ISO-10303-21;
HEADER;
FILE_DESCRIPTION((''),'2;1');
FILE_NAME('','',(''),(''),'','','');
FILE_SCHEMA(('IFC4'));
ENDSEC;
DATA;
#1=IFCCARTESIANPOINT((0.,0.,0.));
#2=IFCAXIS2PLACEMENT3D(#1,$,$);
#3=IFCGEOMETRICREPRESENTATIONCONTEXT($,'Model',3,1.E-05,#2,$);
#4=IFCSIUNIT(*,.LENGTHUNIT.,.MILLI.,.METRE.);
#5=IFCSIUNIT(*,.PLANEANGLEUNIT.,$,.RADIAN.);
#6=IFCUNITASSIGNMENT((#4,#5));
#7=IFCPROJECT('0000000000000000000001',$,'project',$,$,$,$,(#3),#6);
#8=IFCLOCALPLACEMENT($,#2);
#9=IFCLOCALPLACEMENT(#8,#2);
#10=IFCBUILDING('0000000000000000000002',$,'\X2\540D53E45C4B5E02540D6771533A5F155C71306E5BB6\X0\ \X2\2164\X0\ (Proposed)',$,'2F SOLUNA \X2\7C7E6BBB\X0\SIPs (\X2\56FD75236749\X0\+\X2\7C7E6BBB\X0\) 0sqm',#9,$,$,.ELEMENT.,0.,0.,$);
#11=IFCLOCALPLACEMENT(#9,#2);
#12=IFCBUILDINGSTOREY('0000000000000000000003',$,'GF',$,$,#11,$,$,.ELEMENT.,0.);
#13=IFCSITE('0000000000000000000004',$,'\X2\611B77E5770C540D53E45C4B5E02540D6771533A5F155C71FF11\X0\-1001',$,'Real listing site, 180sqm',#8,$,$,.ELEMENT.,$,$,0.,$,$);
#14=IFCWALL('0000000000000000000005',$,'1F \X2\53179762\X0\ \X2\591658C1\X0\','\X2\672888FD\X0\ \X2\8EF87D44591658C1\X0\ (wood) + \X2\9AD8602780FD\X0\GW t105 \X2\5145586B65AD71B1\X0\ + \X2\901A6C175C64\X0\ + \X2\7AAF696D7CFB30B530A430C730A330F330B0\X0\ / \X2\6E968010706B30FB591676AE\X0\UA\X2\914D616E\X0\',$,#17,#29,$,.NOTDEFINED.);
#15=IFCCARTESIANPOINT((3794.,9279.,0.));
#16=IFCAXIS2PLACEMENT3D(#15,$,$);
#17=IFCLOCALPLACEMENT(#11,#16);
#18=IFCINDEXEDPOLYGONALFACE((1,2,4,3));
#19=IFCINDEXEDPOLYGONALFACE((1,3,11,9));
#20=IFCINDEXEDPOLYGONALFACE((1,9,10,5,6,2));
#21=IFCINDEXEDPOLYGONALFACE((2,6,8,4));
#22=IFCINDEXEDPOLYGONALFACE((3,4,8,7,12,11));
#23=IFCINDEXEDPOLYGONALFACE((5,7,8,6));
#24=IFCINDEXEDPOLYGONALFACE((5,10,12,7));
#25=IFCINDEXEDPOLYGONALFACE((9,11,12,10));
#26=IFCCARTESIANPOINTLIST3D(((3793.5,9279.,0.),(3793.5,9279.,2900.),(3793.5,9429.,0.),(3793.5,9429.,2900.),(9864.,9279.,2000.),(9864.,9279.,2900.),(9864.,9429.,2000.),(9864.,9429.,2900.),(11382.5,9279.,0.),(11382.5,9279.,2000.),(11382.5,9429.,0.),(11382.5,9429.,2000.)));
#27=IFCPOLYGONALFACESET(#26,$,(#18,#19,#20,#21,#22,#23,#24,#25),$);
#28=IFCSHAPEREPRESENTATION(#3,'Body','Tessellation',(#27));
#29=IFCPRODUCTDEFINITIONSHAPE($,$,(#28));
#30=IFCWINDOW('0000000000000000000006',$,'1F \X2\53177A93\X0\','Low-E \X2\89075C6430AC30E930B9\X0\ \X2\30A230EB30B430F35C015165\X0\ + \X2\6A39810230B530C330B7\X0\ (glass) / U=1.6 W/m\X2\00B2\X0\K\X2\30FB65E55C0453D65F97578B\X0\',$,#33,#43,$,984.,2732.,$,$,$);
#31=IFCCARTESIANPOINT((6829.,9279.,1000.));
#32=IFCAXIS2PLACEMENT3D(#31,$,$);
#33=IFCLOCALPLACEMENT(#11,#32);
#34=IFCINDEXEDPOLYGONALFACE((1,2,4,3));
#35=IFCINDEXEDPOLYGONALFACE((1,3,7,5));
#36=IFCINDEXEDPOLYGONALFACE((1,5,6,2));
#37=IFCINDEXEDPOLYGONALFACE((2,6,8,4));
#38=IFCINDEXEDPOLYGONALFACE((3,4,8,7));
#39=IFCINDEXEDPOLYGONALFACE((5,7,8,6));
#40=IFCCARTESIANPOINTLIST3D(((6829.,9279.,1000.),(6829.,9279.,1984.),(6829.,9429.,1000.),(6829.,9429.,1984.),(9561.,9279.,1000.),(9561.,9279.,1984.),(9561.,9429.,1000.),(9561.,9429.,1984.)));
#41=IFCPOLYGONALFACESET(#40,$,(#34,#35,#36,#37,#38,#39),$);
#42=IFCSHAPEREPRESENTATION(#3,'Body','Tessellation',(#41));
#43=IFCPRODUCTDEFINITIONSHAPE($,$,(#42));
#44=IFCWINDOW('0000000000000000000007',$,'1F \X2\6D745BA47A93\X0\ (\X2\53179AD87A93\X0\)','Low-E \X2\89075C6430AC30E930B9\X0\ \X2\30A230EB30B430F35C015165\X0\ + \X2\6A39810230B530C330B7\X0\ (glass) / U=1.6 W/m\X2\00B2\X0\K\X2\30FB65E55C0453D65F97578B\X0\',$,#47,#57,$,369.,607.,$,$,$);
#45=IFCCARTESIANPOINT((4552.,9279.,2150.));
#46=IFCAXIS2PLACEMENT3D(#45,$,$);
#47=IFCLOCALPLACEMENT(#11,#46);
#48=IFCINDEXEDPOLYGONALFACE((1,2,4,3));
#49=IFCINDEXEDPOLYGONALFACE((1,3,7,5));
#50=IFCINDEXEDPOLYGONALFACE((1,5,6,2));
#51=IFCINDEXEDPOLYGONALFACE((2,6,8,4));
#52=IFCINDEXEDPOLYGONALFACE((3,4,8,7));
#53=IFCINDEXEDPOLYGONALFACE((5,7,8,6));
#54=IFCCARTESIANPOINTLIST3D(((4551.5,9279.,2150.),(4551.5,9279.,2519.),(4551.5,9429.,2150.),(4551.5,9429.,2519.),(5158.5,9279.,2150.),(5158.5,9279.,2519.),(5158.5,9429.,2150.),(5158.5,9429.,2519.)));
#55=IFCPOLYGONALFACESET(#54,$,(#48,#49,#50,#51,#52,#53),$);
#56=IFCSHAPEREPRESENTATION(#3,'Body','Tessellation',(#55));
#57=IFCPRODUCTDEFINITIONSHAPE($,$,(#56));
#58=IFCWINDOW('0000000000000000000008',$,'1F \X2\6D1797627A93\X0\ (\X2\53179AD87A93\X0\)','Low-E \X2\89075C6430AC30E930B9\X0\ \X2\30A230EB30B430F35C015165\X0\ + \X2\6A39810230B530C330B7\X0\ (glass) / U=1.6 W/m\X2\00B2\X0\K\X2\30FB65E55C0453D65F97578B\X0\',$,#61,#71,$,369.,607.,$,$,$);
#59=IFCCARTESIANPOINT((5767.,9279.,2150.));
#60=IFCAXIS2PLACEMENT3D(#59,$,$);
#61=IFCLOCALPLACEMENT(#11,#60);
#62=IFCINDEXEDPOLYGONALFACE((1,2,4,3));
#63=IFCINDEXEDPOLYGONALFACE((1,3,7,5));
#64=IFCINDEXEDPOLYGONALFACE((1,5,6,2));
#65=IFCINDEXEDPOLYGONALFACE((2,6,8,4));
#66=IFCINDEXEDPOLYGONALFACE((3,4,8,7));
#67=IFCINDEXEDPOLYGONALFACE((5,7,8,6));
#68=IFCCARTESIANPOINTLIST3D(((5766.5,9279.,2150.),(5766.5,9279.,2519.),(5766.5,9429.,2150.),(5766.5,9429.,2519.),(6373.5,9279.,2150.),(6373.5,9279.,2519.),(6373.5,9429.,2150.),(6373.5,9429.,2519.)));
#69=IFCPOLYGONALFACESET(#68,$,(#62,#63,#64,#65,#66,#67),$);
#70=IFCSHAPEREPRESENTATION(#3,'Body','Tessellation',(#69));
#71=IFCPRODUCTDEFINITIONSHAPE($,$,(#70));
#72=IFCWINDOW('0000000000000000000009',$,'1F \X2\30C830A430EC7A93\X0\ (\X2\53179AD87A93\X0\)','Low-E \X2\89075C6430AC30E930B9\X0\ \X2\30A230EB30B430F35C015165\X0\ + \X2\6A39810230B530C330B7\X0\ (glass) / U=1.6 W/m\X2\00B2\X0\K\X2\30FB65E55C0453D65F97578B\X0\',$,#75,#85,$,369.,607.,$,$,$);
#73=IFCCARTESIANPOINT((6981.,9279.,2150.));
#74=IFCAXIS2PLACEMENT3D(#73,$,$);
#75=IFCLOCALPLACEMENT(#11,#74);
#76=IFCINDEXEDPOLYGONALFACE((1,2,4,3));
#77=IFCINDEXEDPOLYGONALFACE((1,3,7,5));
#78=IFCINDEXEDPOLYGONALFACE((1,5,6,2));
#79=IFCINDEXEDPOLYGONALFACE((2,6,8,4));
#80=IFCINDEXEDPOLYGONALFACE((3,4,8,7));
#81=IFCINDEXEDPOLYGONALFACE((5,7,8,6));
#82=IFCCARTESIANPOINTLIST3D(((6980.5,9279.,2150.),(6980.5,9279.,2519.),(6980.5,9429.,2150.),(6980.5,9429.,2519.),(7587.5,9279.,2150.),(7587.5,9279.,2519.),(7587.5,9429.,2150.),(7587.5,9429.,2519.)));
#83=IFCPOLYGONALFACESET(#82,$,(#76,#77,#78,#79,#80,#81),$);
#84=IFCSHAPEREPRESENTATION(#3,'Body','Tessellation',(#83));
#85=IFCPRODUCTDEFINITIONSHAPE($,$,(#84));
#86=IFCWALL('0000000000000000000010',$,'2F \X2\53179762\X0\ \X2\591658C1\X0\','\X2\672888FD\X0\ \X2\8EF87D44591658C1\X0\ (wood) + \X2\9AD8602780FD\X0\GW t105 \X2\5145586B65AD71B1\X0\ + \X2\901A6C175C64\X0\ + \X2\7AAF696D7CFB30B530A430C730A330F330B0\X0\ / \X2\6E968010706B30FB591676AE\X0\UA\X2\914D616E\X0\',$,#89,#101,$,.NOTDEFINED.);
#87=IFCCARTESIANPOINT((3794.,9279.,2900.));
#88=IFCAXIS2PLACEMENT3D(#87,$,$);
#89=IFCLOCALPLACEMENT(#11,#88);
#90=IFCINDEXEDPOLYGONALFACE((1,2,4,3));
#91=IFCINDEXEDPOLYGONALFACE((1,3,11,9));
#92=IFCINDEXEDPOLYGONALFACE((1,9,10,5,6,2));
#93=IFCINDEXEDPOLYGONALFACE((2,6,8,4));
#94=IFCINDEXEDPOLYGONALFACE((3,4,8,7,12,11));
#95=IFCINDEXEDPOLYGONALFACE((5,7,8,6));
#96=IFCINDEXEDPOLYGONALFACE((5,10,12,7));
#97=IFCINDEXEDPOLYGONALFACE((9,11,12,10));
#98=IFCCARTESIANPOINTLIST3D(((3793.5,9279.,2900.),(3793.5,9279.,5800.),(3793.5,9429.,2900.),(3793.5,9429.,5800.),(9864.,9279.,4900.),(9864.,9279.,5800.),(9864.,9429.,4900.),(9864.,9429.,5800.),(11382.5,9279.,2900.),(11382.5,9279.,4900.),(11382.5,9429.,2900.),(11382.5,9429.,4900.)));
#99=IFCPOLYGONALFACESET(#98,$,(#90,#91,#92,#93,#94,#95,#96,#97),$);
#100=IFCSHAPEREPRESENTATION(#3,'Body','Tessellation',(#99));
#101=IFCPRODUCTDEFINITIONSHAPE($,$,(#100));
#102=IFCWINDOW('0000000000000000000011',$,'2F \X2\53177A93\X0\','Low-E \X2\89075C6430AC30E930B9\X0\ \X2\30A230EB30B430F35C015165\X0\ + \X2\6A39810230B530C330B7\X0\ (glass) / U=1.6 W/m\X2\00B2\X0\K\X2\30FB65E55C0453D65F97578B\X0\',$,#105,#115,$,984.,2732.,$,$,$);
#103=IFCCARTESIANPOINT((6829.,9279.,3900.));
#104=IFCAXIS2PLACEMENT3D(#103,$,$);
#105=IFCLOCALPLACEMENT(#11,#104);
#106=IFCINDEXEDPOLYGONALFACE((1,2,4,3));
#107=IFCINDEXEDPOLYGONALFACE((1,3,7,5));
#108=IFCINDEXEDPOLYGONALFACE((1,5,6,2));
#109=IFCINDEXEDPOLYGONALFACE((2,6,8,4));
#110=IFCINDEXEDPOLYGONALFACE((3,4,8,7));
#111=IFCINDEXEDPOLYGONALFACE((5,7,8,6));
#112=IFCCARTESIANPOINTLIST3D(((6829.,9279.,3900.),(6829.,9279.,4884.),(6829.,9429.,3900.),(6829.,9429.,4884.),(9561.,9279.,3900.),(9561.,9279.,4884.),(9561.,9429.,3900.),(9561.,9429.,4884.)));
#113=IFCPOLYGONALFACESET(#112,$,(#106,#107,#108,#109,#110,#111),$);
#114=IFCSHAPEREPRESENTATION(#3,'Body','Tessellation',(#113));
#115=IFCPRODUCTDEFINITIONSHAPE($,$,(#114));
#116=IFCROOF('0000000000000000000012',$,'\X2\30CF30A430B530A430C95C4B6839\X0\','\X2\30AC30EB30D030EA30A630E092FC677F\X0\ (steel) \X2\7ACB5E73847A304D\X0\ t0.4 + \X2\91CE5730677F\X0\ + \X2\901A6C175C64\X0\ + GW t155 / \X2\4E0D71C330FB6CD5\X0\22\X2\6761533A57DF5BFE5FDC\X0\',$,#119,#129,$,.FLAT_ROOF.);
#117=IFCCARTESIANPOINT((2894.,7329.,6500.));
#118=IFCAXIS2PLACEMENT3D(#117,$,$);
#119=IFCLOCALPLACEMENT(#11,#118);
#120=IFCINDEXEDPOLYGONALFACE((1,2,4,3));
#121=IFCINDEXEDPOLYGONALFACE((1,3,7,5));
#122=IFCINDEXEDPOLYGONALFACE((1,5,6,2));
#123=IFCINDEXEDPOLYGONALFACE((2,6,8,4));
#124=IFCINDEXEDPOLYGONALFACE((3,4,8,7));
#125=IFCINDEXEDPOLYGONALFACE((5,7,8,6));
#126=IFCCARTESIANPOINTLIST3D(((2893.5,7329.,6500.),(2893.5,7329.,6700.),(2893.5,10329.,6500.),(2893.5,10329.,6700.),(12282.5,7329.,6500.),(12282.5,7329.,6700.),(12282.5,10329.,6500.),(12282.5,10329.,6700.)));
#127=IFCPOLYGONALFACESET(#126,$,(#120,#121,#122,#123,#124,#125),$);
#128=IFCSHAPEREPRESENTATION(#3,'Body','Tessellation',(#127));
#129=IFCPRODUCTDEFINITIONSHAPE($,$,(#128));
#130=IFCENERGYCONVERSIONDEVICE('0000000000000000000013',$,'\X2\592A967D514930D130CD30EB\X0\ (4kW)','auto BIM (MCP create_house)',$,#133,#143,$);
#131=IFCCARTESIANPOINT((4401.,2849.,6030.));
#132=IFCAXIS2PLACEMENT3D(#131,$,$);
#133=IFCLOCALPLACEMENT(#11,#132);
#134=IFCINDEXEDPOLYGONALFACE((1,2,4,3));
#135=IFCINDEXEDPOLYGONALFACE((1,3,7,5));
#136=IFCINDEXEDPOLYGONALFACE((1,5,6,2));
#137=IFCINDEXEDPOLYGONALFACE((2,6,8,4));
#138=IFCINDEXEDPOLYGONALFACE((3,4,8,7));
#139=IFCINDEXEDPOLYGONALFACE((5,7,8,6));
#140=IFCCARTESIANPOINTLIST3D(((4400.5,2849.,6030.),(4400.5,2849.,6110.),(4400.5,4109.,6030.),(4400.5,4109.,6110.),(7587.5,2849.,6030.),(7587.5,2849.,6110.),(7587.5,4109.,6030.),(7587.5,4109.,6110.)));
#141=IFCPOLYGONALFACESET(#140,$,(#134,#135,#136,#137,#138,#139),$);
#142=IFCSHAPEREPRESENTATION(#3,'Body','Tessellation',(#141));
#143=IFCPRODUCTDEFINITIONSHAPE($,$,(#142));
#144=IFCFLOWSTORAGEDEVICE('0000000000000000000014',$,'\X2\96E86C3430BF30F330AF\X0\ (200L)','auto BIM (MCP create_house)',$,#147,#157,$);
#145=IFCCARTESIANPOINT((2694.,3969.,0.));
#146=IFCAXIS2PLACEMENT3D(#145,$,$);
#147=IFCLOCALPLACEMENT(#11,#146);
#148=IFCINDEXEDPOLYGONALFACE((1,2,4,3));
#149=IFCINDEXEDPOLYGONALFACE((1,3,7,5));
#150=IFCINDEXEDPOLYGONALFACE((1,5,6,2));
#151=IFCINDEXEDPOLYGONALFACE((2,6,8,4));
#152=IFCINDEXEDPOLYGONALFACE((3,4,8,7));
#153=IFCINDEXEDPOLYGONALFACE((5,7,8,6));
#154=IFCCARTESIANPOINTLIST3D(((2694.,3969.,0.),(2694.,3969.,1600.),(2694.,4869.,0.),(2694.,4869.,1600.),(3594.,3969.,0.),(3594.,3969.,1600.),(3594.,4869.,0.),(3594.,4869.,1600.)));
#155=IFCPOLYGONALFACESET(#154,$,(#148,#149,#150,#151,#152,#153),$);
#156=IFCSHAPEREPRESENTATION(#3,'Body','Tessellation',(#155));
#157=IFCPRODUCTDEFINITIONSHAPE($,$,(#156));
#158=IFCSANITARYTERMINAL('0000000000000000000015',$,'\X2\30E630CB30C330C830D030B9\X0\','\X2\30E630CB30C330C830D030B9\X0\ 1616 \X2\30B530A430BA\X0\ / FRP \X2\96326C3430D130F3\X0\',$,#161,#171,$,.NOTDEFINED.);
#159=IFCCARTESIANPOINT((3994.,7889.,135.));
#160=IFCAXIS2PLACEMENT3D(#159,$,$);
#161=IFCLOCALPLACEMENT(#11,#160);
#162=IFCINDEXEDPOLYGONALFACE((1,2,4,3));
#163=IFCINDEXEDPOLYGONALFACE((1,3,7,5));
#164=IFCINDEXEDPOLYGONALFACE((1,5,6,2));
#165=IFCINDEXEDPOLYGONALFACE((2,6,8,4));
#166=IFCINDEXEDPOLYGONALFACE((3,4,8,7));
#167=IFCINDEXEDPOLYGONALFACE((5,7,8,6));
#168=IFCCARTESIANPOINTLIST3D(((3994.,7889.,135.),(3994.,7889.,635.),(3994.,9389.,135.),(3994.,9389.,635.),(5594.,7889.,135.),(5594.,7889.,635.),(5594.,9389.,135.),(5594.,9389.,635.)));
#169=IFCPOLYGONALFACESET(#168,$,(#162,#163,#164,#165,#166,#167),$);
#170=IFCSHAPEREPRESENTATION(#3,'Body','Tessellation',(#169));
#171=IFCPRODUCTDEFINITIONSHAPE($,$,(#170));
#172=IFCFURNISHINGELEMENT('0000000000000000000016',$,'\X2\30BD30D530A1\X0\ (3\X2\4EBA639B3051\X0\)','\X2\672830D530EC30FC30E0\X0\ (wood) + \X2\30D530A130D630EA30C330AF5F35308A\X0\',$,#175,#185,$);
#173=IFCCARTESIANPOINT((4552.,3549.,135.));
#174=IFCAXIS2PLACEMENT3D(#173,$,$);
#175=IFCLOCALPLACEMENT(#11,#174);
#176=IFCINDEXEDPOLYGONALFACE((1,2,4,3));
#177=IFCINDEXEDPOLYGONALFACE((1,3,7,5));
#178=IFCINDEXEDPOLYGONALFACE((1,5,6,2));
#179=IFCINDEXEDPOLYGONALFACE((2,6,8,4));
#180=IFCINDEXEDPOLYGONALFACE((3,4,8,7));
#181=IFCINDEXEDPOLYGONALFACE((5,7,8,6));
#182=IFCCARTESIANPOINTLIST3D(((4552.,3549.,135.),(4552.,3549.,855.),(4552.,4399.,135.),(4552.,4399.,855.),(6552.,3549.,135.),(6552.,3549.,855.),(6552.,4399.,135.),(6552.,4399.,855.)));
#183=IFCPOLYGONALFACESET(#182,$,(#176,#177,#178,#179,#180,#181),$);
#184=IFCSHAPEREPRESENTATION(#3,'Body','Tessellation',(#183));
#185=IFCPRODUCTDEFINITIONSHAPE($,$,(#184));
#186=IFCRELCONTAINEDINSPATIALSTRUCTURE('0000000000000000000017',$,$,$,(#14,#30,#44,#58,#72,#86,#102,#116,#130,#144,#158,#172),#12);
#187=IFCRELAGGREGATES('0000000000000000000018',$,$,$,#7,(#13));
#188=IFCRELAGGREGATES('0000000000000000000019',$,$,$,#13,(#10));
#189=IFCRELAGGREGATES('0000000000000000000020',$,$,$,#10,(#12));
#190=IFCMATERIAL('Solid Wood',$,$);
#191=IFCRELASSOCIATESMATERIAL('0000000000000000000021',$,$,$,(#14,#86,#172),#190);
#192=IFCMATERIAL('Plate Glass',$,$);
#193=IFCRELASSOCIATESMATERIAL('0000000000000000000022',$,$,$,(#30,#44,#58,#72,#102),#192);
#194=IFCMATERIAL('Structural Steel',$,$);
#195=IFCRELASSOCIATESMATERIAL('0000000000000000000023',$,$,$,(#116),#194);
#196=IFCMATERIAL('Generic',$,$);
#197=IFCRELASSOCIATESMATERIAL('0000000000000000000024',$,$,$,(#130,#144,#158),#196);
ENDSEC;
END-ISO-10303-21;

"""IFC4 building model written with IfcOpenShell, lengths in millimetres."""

from ifc_helpers import new_model, si_unit, frame, frame_2d, origin, place, context, project, spatial, rectangle, extrude, material, element, fill, save


model = new_model("IFC4")

# Units and contexts
model_context = context("Model", 3, precision=1e-05, world=origin())
ifc_project = project(units=[si_unit("LENGTHUNIT", "METRE", prefix="MILLI"), si_unit("PLANEANGLEUNIT", "RADIAN")], contexts=[model_context])

# Site, building, storey
site_placement = place(None, origin())
site = spatial("IfcSite", under=ifc_project, at=site_placement, Name="愛知県名古屋市名東区引山１-1001", ObjectType="Real listing site, 180sqm", CompositionType="ELEMENT", RefElevation=0.0)
building_placement = place(site_placement, origin())
building = spatial("IfcBuilding", under=site, at=building_placement, Name="名古屋市名東区引山の家 Ⅴ (Proposed)", ObjectType="2F SOLUNA 籾殻SIPs (国産杉+籾殻) 0sqm", CompositionType="ELEMENT", ElevationOfRefHeight=0.0, ElevationOfTerrain=0.0)
storey_placement = place(building_placement, origin())
storey = spatial("IfcBuildingStorey", under=building, at=storey_placement, Name="GF", CompositionType="ELEMENT", Elevation=0.0)

# Wall, openings, windows
ifc_material_1 = material(Name="Solid Wood")
wall_1_placement = place(storey_placement, frame((3794.0, 9279.0, 0.0)))
wall_1 = element("IfcWall", 1, at=wall_1_placement, inside=storey, material=ifc_material_1, Name="1F 北面 外壁", Description="木製 軸組外壁 (wood) + 高性能GW t105 充填断熱 + 通気層 + 窯業系サイディング / 準耐火・外皮UA配慮", PredefinedType="NOTDEFINED", context=model_context, shape_type="SweptSolid", body=[
    extrude(rectangle(XDim=7589.0, YDim=150.0, at=frame_2d((3794.0, 75.0))), frame((3794.0, 9279.0, 0.0)), (0.0, 0.0, 1.0), 2900.0),
])
opening_1_placement = place(storey_placement, frame((6829.0, 9279.0, 1000.0)))
opening_1 = element("IfcOpeningElement", 2, at=opening_1_placement, cuts=wall_1, PredefinedType="NOTDEFINED", context=model_context, shape_type="SweptSolid", body=[
    extrude(rectangle(XDim=2732.0, YDim=150.0, at=frame_2d((1366.0, 75.0))), frame((6829.0, 9279.0, 1000.0)), (0.0, 0.0, 1.0), 984.0),
])
opening_2_placement = place(storey_placement, frame((4552.0, 9279.0, 2150.0)))
opening_2 = element("IfcOpeningElement", 3, at=opening_2_placement, cuts=wall_1, PredefinedType="NOTDEFINED", context=model_context, shape_type="SweptSolid", body=[
    extrude(rectangle(XDim=607.0, YDim=150.0, at=frame_2d((303.0, 75.0))), frame((4552.0, 9279.0, 2150.0)), (0.0, 0.0, 1.0), 369.0),
])
opening_3_placement = place(storey_placement, frame((5767.0, 9279.0, 2150.0)))
opening_3 = element("IfcOpeningElement", 4, at=opening_3_placement, cuts=wall_1, PredefinedType="NOTDEFINED", context=model_context, shape_type="SweptSolid", body=[
    extrude(rectangle(XDim=607.0, YDim=150.0, at=frame_2d((303.0, 75.0))), frame((5767.0, 9279.0, 2150.0)), (0.0, 0.0, 1.0), 369.0),
])
opening_4_placement = place(storey_placement, frame((6981.0, 9279.0, 2150.0)))
opening_4 = element("IfcOpeningElement", 5, at=opening_4_placement, cuts=wall_1, PredefinedType="NOTDEFINED", context=model_context, shape_type="SweptSolid", body=[
    extrude(rectangle(XDim=607.0, YDim=150.0, at=frame_2d((303.0, 75.0))), frame((6981.0, 9279.0, 2150.0)), (0.0, 0.0, 1.0), 369.0),
])
ifc_material_2 = material(Name="Plate Glass")
window_1_placement = place(storey_placement, frame((6829.0, 9279.0, 1000.0)))
window_1 = element("IfcWindow", 6, at=window_1_placement, inside=storey, material=ifc_material_2, Name="1F 北窓", Description="Low-E 複層ガラス アルゴン封入 + 樹脂サッシ (glass) / U=1.6 W/m²K・日射取得型", OverallHeight=984.0, OverallWidth=2732.0, context=model_context, shape_type="SweptSolid", body=[
    extrude(rectangle(XDim=2732.0, YDim=150.0, at=frame_2d((1366.0, 75.0))), frame((6829.0, 9279.0, 1000.0)), (0.0, 0.0, 1.0), 984.0),
])
fill(opening_1, window_1)
window_2_placement = place(storey_placement, frame((4552.0, 9279.0, 2150.0)))
window_2 = element("IfcWindow", 7, at=window_2_placement, inside=storey, material=ifc_material_2, Name="1F 浴室窓 (北高窓)", Description="Low-E 複層ガラス アルゴン封入 + 樹脂サッシ (glass) / U=1.6 W/m²K・日射取得型", OverallHeight=369.0, OverallWidth=607.0, context=model_context, shape_type="SweptSolid", body=[
    extrude(rectangle(XDim=607.0, YDim=150.0, at=frame_2d((303.0, 75.0))), frame((4552.0, 9279.0, 2150.0)), (0.0, 0.0, 1.0), 369.0),
])
fill(opening_2, window_2)
window_3_placement = place(storey_placement, frame((5767.0, 9279.0, 2150.0)))
window_3 = element("IfcWindow", 8, at=window_3_placement, inside=storey, material=ifc_material_2, Name="1F 洗面窓 (北高窓)", Description="Low-E 複層ガラス アルゴン封入 + 樹脂サッシ (glass) / U=1.6 W/m²K・日射取得型", OverallHeight=369.0, OverallWidth=607.0, context=model_context, shape_type="SweptSolid", body=[
    extrude(rectangle(XDim=607.0, YDim=150.0, at=frame_2d((303.0, 75.0))), frame((5767.0, 9279.0, 2150.0)), (0.0, 0.0, 1.0), 369.0),
])
fill(opening_3, window_3)
window_4_placement = place(storey_placement, frame((6981.0, 9279.0, 2150.0)))
window_4 = element("IfcWindow", 9, at=window_4_placement, inside=storey, material=ifc_material_2, Name="1F トイレ窓 (北高窓)", Description="Low-E 複層ガラス アルゴン封入 + 樹脂サッシ (glass) / U=1.6 W/m²K・日射取得型", OverallHeight=369.0, OverallWidth=607.0, context=model_context, shape_type="SweptSolid", body=[
    extrude(rectangle(XDim=607.0, YDim=150.0, at=frame_2d((303.0, 75.0))), frame((6981.0, 9279.0, 2150.0)), (0.0, 0.0, 1.0), 369.0),
])
fill(opening_4, window_4)

# Wall, opening, window
wall_2_placement = place(storey_placement, frame((3794.0, 9279.0, 2900.0)))
wall_2 = element("IfcWall", 10, at=wall_2_placement, inside=storey, material=ifc_material_1, Name="2F 北面 外壁", Description="木製 軸組外壁 (wood) + 高性能GW t105 充填断熱 + 通気層 + 窯業系サイディング / 準耐火・外皮UA配慮", PredefinedType="NOTDEFINED", context=model_context, shape_type="SweptSolid", body=[
    extrude(rectangle(XDim=7589.0, YDim=150.0, at=frame_2d((3794.0, 75.0))), frame((3794.0, 9279.0, 2900.0)), (0.0, 0.0, 1.0), 2900.0),
])
opening_5_placement = place(storey_placement, frame((6829.0, 9279.0, 3900.0)))
opening_5 = element("IfcOpeningElement", 11, at=opening_5_placement, cuts=wall_2, PredefinedType="NOTDEFINED", context=model_context, shape_type="SweptSolid", body=[
    extrude(rectangle(XDim=2732.0, YDim=150.0, at=frame_2d((1366.0, 75.0))), frame((6829.0, 9279.0, 3900.0)), (0.0, 0.0, 1.0), 984.0),
])
window_5_placement = place(storey_placement, frame((6829.0, 9279.0, 3900.0)))
window_5 = element("IfcWindow", 12, at=window_5_placement, inside=storey, material=ifc_material_2, Name="2F 北窓", Description="Low-E 複層ガラス アルゴン封入 + 樹脂サッシ (glass) / U=1.6 W/m²K・日射取得型", OverallHeight=984.0, OverallWidth=2732.0, context=model_context, shape_type="SweptSolid", body=[
    extrude(rectangle(XDim=2732.0, YDim=150.0, at=frame_2d((1366.0, 75.0))), frame((6829.0, 9279.0, 3900.0)), (0.0, 0.0, 1.0), 984.0),
])
fill(opening_5, window_5)

# Roof
ifc_material_3 = material(Name="Structural Steel")
roof_placement = place(storey_placement, frame((2894.0, 7329.0, 6500.0)))
element("IfcRoof", 13, at=roof_placement, inside=storey, material=ifc_material_3, Name="ハイサイド屋根", Description="ガルバリウム鋼板 (steel) 立平葺き t0.4 + 野地板 + 通気層 + GW t155 / 不燃・法22条区域対応", PredefinedType="FLAT_ROOF", context=model_context, shape_type="SweptSolid", body=[
    extrude(rectangle(XDim=9389.0, YDim=3000.0, at=frame_2d((4694.0, 1500.0))), frame((2894.0, 7329.0, 6500.0)), (0.0, 0.0, 1.0), 200.0),
])

# Energy conversion device
ifc_material_4 = material(Name="Generic")
energy_conversion_device_placement = place(storey_placement, frame((4401.0, 2849.0, 6030.0)))
element("IfcEnergyConversionDevice", 14, at=energy_conversion_device_placement, inside=storey, material=ifc_material_4, Name="太陽光パネル (4kW)", Description="auto BIM (MCP create_house)", context=model_context, shape_type="SweptSolid", body=[
    extrude(rectangle(XDim=3187.0, YDim=1260.0, at=frame_2d((1593.0, 630.0))), frame((4401.0, 2849.0, 6030.0)), (0.0, 0.0, 1.0), 80.0),
])

# Flow storage device
flow_storage_device_placement = place(storey_placement, frame((2694.0, 3969.0, 0.0)))
element("IfcFlowStorageDevice", 15, at=flow_storage_device_placement, inside=storey, material=ifc_material_4, Name="雨水タンク (200L)", Description="auto BIM (MCP create_house)", context=model_context, shape_type="SweptSolid", body=[
    extrude(rectangle(XDim=900.0, YDim=900.0, at=frame_2d((450.0, 450.0))), frame((2694.0, 3969.0, 0.0)), (0.0, 0.0, 1.0), 1600.0),
])

# Sanitary terminal
sanitary_terminal_placement = place(storey_placement, frame((3994.0, 7889.0, 135.0)))
element("IfcSanitaryTerminal", 16, at=sanitary_terminal_placement, inside=storey, material=ifc_material_4, Name="ユニットバス", Description="ユニットバス 1616 サイズ / FRP 防水パン", PredefinedType="NOTDEFINED", context=model_context, shape_type="SweptSolid", body=[
    extrude(rectangle(XDim=1600.0, YDim=1500.0, at=frame_2d((800.0, 750.0))), frame((3994.0, 7889.0, 135.0)), (0.0, 0.0, 1.0), 500.0),
])

# Furnishing element
furnishing_1_placement = place(storey_placement, frame((4552.0, 3549.0, 135.0)))
element("IfcFurnishingElement", 17, at=furnishing_1_placement, inside=storey, material=ifc_material_1, Name="ソファ (3人掛け)", Description="木フレーム (wood) + ファブリック張り", context=model_context, shape_type="SweptSolid", body=[
    extrude(rectangle(XDim=2000.0, YDim=850.0, at=frame_2d((1000.0, 425.0))), frame((4552.0, 3549.0, 135.0)), (0.0, 0.0, 1.0), 720.0),
])

save(model, "model.ifc")
